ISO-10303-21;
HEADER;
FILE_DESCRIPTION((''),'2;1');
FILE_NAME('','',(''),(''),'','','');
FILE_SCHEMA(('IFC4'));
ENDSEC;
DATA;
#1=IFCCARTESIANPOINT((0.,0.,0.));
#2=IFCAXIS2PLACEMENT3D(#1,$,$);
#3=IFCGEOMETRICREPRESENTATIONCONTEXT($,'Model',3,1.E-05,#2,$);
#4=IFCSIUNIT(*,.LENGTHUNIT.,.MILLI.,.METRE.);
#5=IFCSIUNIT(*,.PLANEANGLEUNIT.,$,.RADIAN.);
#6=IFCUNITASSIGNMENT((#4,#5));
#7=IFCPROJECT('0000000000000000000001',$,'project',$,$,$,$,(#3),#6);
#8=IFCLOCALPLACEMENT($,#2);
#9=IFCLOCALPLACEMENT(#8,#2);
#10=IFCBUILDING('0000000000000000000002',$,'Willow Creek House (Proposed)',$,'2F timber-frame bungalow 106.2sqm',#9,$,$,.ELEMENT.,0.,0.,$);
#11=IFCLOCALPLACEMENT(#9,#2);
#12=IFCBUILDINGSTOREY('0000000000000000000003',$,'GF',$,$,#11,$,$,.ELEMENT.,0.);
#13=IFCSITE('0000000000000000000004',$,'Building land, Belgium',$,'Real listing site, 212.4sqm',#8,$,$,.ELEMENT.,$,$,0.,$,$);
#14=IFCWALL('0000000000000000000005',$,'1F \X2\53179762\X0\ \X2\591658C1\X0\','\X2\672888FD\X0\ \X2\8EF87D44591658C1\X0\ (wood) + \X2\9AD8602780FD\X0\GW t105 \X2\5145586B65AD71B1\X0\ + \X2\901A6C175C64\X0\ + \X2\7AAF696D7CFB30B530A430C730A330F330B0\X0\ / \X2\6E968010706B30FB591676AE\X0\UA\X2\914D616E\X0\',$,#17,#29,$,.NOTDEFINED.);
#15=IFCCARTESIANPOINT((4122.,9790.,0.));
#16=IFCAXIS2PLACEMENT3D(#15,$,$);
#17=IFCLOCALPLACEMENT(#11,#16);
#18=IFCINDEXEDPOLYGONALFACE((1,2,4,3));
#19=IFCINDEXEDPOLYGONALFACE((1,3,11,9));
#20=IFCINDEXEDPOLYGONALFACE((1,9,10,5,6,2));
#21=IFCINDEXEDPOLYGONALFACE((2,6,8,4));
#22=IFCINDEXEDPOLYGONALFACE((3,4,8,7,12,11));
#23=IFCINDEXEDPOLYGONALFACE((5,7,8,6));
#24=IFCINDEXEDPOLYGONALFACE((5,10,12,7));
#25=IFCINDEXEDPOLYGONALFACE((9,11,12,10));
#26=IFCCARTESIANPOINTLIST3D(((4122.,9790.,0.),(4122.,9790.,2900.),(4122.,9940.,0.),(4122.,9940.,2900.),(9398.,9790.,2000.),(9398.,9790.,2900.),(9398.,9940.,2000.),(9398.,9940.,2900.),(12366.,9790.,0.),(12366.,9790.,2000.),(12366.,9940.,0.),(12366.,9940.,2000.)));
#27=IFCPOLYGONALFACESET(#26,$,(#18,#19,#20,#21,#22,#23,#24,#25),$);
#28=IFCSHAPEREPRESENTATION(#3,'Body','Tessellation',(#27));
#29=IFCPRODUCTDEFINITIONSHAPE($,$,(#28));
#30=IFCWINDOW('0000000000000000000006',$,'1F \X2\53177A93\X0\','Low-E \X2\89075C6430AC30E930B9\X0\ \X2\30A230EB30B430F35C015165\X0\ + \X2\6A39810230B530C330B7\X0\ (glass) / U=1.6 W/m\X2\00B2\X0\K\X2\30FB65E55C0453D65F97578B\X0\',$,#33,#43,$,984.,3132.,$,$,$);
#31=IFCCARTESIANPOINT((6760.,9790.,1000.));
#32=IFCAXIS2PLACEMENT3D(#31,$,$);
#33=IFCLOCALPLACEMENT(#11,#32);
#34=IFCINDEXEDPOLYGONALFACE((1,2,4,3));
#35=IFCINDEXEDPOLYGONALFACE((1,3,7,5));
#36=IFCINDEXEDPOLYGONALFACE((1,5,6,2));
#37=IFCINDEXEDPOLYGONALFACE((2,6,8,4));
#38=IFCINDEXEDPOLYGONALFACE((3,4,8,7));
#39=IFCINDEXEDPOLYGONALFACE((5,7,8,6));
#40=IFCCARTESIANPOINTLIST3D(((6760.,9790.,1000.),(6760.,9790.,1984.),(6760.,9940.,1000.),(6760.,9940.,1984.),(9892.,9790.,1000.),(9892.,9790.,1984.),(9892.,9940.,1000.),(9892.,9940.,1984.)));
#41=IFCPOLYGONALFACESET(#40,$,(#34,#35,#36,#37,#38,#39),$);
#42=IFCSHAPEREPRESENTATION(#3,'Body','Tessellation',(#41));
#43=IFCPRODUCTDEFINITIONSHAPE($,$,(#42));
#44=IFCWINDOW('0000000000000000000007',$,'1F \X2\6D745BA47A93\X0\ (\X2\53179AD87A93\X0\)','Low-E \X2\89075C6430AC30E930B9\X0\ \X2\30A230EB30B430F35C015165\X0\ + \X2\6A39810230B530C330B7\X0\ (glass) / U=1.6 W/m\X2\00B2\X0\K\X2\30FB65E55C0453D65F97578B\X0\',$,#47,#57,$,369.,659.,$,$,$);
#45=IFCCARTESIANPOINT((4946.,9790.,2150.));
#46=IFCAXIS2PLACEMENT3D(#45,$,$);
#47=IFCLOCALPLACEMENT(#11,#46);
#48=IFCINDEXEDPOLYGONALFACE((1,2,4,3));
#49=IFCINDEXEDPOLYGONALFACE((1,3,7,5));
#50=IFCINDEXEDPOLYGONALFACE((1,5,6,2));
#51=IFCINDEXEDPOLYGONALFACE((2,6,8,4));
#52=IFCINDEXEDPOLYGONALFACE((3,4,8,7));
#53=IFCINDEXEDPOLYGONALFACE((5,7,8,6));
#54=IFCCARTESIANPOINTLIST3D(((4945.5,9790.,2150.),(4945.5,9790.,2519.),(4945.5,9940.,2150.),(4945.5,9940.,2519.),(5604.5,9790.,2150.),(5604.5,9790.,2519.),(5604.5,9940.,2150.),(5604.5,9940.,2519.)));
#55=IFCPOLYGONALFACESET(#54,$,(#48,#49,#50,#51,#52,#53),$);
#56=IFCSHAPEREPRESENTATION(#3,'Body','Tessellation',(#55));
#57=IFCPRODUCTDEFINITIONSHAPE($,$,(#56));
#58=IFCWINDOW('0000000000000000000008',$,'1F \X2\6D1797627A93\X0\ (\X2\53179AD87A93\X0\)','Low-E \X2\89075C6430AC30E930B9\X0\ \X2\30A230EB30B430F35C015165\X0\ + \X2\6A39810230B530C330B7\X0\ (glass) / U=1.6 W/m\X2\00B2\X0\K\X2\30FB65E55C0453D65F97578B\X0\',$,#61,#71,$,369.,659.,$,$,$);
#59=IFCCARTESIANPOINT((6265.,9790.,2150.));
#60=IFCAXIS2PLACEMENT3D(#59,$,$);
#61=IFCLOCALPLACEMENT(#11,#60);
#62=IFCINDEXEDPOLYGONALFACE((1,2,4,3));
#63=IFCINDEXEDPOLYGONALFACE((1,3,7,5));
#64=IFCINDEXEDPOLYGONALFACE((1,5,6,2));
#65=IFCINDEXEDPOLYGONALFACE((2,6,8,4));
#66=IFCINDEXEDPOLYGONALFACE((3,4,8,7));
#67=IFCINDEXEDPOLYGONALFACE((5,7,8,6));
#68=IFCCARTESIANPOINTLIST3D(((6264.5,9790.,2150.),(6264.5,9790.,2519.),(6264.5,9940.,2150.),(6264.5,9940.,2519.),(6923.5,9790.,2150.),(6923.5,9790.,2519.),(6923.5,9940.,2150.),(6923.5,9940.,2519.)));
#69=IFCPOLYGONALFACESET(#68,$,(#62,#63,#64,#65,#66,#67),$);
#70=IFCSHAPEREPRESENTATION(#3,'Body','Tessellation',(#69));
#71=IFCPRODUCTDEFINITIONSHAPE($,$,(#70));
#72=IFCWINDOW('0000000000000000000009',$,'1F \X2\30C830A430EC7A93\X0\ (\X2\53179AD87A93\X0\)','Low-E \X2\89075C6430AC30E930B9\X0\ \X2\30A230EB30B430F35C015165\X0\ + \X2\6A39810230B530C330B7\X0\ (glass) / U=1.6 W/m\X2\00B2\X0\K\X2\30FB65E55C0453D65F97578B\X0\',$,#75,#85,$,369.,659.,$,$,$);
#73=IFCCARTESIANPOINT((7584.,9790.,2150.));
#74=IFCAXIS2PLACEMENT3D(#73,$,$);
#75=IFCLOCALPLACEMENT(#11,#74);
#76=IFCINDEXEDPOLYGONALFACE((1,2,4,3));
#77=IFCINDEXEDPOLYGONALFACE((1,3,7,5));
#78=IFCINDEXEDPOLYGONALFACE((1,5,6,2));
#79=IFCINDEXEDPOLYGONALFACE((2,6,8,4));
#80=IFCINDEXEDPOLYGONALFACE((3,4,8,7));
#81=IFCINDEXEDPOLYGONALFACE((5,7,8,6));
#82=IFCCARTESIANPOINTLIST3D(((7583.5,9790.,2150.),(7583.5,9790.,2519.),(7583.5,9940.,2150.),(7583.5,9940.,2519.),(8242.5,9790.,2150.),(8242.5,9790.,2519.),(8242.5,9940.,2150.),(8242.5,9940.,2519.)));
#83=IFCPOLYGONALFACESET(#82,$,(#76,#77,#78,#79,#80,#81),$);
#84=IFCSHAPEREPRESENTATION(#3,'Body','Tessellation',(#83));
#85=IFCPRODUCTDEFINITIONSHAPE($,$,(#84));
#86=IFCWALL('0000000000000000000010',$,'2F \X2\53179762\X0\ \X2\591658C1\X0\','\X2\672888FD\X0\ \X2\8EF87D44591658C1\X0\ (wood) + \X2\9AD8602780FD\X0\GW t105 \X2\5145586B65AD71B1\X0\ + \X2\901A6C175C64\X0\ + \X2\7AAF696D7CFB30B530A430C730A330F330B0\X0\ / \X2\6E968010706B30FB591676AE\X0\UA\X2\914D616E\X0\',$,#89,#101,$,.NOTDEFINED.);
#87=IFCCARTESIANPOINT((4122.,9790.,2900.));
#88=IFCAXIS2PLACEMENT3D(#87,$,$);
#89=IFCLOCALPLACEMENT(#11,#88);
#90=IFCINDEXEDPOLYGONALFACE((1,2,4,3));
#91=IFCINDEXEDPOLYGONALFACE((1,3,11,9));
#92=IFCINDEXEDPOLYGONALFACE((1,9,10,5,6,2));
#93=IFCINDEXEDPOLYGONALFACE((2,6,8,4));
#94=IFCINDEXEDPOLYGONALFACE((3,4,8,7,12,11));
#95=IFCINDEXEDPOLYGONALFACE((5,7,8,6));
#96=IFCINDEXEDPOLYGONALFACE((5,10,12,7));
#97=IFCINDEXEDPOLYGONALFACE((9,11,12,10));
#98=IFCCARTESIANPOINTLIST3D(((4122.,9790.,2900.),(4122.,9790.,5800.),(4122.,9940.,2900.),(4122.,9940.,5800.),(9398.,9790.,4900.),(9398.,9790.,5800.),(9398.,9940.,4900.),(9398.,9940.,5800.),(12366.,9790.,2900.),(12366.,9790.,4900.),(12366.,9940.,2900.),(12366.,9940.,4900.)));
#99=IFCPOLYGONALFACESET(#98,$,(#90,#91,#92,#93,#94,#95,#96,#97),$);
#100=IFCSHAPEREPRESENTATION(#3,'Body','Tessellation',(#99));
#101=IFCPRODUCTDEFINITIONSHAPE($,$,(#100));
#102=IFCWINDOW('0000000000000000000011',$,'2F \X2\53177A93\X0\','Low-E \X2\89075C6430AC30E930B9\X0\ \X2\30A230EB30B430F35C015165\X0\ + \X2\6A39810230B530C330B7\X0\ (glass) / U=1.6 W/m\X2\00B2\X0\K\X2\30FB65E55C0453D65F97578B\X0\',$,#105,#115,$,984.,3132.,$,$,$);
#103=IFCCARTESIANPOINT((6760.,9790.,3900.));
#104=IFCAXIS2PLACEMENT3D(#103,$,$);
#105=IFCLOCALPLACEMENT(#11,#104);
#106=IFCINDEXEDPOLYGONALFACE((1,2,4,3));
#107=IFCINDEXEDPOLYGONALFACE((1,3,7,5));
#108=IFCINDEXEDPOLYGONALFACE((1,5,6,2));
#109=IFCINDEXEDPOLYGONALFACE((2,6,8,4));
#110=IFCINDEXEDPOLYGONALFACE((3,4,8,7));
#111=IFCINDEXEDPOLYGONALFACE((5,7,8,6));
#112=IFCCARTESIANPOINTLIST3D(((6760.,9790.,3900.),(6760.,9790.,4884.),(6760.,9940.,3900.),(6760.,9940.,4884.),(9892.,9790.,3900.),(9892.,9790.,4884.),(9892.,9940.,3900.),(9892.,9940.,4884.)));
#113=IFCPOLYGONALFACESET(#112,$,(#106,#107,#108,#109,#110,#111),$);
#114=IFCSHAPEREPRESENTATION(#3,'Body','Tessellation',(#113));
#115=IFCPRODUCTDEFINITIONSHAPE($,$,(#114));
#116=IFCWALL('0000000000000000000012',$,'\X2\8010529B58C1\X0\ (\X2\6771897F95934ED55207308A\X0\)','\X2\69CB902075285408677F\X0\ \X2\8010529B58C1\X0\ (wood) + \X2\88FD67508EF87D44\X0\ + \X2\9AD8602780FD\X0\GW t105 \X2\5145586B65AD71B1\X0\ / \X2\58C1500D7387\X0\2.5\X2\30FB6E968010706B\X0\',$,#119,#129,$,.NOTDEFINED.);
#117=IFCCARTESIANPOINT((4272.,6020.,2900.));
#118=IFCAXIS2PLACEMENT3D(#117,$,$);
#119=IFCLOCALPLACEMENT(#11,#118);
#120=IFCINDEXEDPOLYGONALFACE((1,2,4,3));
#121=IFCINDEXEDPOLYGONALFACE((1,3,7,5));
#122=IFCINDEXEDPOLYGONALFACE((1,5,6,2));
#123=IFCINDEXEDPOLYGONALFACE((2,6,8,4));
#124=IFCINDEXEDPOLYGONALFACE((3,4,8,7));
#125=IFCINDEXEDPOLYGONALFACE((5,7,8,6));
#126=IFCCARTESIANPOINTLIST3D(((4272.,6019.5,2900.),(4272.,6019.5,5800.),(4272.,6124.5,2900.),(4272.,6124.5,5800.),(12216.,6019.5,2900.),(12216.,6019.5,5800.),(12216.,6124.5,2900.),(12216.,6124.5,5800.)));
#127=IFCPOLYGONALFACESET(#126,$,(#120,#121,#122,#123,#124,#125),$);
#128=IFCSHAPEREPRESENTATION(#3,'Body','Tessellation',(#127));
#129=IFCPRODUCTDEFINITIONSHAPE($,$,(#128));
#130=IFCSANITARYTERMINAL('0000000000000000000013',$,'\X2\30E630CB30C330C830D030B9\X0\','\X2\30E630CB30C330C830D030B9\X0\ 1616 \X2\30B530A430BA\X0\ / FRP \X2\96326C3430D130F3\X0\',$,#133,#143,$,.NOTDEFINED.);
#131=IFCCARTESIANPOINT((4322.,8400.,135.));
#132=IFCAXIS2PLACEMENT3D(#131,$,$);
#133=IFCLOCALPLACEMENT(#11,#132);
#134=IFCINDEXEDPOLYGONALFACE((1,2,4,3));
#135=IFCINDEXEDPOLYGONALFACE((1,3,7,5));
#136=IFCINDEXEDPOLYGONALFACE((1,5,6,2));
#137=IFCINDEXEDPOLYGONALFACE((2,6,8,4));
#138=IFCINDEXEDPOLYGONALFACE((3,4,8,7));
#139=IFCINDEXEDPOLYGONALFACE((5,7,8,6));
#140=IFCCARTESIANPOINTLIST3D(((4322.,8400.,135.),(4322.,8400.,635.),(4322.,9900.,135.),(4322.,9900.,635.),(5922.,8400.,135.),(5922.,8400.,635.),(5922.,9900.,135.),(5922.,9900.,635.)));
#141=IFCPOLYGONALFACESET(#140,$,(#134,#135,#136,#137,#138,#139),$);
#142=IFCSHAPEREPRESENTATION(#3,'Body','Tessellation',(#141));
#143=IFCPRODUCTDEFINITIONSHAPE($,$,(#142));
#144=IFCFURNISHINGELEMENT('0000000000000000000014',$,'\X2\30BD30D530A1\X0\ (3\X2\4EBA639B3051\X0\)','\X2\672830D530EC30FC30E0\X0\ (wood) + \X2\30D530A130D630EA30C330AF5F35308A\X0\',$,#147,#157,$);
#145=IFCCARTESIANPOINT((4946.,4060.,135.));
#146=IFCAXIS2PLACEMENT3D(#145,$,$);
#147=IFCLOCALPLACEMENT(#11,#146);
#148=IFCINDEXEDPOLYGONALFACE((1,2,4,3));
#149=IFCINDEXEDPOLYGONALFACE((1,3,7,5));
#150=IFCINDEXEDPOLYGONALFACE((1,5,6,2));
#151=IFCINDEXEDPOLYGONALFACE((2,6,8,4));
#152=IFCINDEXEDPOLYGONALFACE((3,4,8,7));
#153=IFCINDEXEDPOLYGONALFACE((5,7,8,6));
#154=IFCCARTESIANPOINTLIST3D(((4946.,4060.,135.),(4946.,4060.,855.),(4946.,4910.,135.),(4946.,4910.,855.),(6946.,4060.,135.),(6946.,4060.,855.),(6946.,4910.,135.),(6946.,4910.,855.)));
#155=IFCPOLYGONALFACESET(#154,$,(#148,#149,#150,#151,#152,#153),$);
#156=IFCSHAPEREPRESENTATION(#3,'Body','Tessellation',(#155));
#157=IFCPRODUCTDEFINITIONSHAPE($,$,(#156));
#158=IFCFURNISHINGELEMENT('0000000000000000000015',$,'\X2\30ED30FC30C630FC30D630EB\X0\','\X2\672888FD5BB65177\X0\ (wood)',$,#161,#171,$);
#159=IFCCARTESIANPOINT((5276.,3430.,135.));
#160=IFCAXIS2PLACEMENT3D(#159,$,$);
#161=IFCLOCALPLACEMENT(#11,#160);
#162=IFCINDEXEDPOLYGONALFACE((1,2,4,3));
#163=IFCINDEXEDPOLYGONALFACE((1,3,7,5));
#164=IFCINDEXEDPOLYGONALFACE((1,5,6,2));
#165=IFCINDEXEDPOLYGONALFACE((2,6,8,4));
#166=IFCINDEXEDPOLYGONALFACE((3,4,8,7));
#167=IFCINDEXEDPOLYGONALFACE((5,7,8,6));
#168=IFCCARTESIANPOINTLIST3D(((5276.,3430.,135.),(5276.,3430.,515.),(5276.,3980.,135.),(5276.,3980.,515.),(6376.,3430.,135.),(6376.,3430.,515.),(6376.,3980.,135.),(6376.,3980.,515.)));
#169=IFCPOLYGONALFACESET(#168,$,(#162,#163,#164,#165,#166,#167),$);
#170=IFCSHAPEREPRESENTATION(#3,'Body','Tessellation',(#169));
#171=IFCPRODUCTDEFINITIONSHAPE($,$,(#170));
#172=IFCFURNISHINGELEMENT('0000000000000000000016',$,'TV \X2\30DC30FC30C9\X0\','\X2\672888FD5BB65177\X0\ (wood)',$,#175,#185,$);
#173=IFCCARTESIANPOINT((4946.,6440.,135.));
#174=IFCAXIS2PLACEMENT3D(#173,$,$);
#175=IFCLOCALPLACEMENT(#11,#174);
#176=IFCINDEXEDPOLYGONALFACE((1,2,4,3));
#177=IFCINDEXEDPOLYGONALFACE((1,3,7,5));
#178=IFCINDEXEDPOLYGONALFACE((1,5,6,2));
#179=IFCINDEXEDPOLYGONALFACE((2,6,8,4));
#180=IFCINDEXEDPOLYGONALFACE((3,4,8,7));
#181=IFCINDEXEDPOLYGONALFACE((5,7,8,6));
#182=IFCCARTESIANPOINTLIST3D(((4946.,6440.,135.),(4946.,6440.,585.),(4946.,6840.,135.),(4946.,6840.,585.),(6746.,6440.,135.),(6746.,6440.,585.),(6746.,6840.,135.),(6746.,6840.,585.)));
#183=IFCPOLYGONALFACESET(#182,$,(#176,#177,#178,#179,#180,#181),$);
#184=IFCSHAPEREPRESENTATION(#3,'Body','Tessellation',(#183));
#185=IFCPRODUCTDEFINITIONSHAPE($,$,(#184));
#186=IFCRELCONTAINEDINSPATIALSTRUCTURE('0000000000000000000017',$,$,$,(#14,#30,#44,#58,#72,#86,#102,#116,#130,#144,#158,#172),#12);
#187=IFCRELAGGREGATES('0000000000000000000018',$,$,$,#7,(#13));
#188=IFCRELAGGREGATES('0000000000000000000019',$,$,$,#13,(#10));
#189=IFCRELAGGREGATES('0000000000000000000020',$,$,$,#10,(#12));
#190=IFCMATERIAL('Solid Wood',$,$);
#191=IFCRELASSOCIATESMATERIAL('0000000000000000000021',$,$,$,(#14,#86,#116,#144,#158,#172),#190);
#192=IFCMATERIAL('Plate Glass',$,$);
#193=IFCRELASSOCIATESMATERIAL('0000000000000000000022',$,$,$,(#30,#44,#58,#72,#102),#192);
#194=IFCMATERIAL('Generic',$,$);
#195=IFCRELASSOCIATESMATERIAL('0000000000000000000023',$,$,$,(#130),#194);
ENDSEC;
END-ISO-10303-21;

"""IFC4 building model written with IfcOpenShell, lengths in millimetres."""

from ifc_helpers import new_model, si_unit, frame, frame_2d, origin, place, context, project, spatial, rectangle, extrude, material, element, fill, save


model = new_model("IFC4")

# Units and contexts
model_context = context("Model", 3, precision=1e-05, world=origin())
ifc_project = project(units=[si_unit("LENGTHUNIT", "METRE", prefix="MILLI"), si_unit("PLANEANGLEUNIT", "RADIAN")], contexts=[model_context])

# Site, building, storey
site_placement = place(None, origin())
site = spatial("IfcSite", under=ifc_project, at=site_placement, Name="Building land, Belgium", ObjectType="Real listing site, 212.4sqm", CompositionType="ELEMENT", RefElevation=0.0)
building_placement = place(site_placement, origin())
building = spatial("IfcBuilding", under=site, at=building_placement, Name="Willow Creek House (Proposed)", ObjectType="2F timber-frame bungalow 106.2sqm", CompositionType="ELEMENT", ElevationOfRefHeight=0.0, ElevationOfTerrain=0.0)
storey_placement = place(building_placement, origin())
storey = spatial("IfcBuildingStorey", under=building, at=storey_placement, Name="GF", CompositionType="ELEMENT", Elevation=0.0)

# Wall, openings, windows
ifc_material_1 = material(Name="Solid Wood")
wall_1_placement = place(storey_placement, frame((4122.0, 9790.0, 0.0)))
wall_1 = element("IfcWall", 1, at=wall_1_placement, inside=storey, material=ifc_material_1, Name="1F 北面 外壁", Description="木製 軸組外壁 (wood) + 高性能GW t105 充填断熱 + 通気層 + 窯業系サイディング / 準耐火・外皮UA配慮", PredefinedType="NOTDEFINED", context=model_context, shape_type="SweptSolid", body=[
    extrude(rectangle(XDim=8244.0, YDim=150.0, at=frame_2d((4122.0, 75.0))), frame((4122.0, 9790.0, 0.0)), (0.0, 0.0, 1.0), 2900.0),
])
opening_1_placement = place(storey_placement, frame((6760.0, 9790.0, 1000.0)))
opening_1 = element("IfcOpeningElement", 2, at=opening_1_placement, cuts=wall_1, PredefinedType="NOTDEFINED", context=model_context, shape_type="SweptSolid", body=[
    extrude(rectangle(XDim=3132.0, YDim=150.0, at=frame_2d((1566.0, 75.0))), frame((6760.0, 9790.0, 1000.0)), (0.0, 0.0, 1.0), 984.0),
])
opening_2_placement = place(storey_placement, frame((4946.0, 9790.0, 2150.0)))
opening_2 = element("IfcOpeningElement", 3, at=opening_2_placement, cuts=wall_1, PredefinedType="NOTDEFINED", context=model_context, shape_type="SweptSolid", body=[
    extrude(rectangle(XDim=659.0, YDim=150.0, at=frame_2d((329.0, 75.0))), frame((4946.0, 9790.0, 2150.0)), (0.0, 0.0, 1.0), 369.0),
])
opening_3_placement = place(storey_placement, frame((6265.0, 9790.0, 2150.0)))
opening_3 = element("IfcOpeningElement", 4, at=opening_3_placement, cuts=wall_1, PredefinedType="NOTDEFINED", context=model_context, shape_type="SweptSolid", body=[
    extrude(rectangle(XDim=659.0, YDim=150.0, at=frame_2d((329.0, 75.0))), frame((6265.0, 9790.0, 2150.0)), (0.0, 0.0, 1.0), 369.0),
])
opening_4_placement = place(storey_placement, frame((7584.0, 9790.0, 2150.0)))
opening_4 = element("IfcOpeningElement", 5, at=opening_4_placement, cuts=wall_1, PredefinedType="NOTDEFINED", context=model_context, shape_type="SweptSolid", body=[
    extrude(rectangle(XDim=659.0, YDim=150.0, at=frame_2d((329.0, 75.0))), frame((7584.0, 9790.0, 2150.0)), (0.0, 0.0, 1.0), 369.0),
])
ifc_material_2 = material(Name="Plate Glass")
window_1_placement = place(storey_placement, frame((6760.0, 9790.0, 1000.0)))
window_1 = element("IfcWindow", 6, at=window_1_placement, inside=storey, material=ifc_material_2, Name="1F 北窓", Description="Low-E 複層ガラス アルゴン封入 + 樹脂サッシ (glass) / U=1.6 W/m²K・日射取得型", OverallHeight=984.0, OverallWidth=3132.0, context=model_context, shape_type="SweptSolid", body=[
    extrude(rectangle(XDim=3132.0, YDim=150.0, at=frame_2d((1566.0, 75.0))), frame((6760.0, 9790.0, 1000.0)), (0.0, 0.0, 1.0), 984.0),
])
fill(opening_1, window_1)
window_2_placement = place(storey_placement, frame((4946.0, 9790.0, 2150.0)))
window_2 = element("IfcWindow", 7, at=window_2_placement, inside=storey, material=ifc_material_2, Name="1F 浴室窓 (北高窓)", Description="Low-E 複層ガラス アルゴン封入 + 樹脂サッシ (glass) / U=1.6 W/m²K・日射取得型", OverallHeight=369.0, OverallWidth=659.0, context=model_context, shape_type="SweptSolid", body=[
    extrude(rectangle(XDim=659.0, YDim=150.0, at=frame_2d((329.0, 75.0))), frame((4946.0, 9790.0, 2150.0)), (0.0, 0.0, 1.0), 369.0),
])
fill(opening_2, window_2)
window_3_placement = place(storey_placement, frame((6265.0, 9790.0, 2150.0)))
window_3 = element("IfcWindow", 8, at=window_3_placement, inside=storey, material=ifc_material_2, Name="1F 洗面窓 (北高窓)", Description="Low-E 複層ガラス アルゴン封入 + 樹脂サッシ (glass) / U=1.6 W/m²K・日射取得型", OverallHeight=369.0, OverallWidth=659.0, context=model_context, shape_type="SweptSolid", body=[
    extrude(rectangle(XDim=659.0, YDim=150.0, at=frame_2d((329.0, 75.0))), frame((6265.0, 9790.0, 2150.0)), (0.0, 0.0, 1.0), 369.0),
])
fill(opening_3, window_3)
window_4_placement = place(storey_placement, frame((7584.0, 9790.0, 2150.0)))
window_4 = element("IfcWindow", 9, at=window_4_placement, inside=storey, material=ifc_material_2, Name="1F トイレ窓 (北高窓)", Description="Low-E 複層ガラス アルゴン封入 + 樹脂サッシ (glass) / U=1.6 W/m²K・日射取得型", OverallHeight=369.0, OverallWidth=659.0, context=model_context, shape_type="SweptSolid", body=[
    extrude(rectangle(XDim=659.0, YDim=150.0, at=frame_2d((329.0, 75.0))), frame((7584.0, 9790.0, 2150.0)), (0.0, 0.0, 1.0), 369.0),
])
fill(opening_4, window_4)

# Wall, opening, window
wall_2_placement = place(storey_placement, frame((4122.0, 9790.0, 2900.0)))
wall_2 = element("IfcWall", 10, at=wall_2_placement, inside=storey, material=ifc_material_1, Name="2F 北面 外壁", Description="木製 軸組外壁 (wood) + 高性能GW t105 充填断熱 + 通気層 + 窯業系サイディング / 準耐火・外皮UA配慮", PredefinedType="NOTDEFINED", context=model_context, shape_type="SweptSolid", body=[
    extrude(rectangle(XDim=8244.0, YDim=150.0, at=frame_2d((4122.0, 75.0))), frame((4122.0, 9790.0, 2900.0)), (0.0, 0.0, 1.0), 2900.0),
])
opening_5_placement = place(storey_placement, frame((6760.0, 9790.0, 3900.0)))
opening_5 = element("IfcOpeningElement", 11, at=opening_5_placement, cuts=wall_2, PredefinedType="NOTDEFINED", context=model_context, shape_type="SweptSolid", body=[
    extrude(rectangle(XDim=3132.0, YDim=150.0, at=frame_2d((1566.0, 75.0))), frame((6760.0, 9790.0, 3900.0)), (0.0, 0.0, 1.0), 984.0),
])
window_5_placement = place(storey_placement, frame((6760.0, 9790.0, 3900.0)))
window_5 = element("IfcWindow", 12, at=window_5_placement, inside=storey, material=ifc_material_2, Name="2F 北窓", Description="Low-E 複層ガラス アルゴン封入 + 樹脂サッシ (glass) / U=1.6 W/m²K・日射取得型", OverallHeight=984.0, OverallWidth=3132.0, context=model_context, shape_type="SweptSolid", body=[
    extrude(rectangle(XDim=3132.0, YDim=150.0, at=frame_2d((1566.0, 75.0))), frame((6760.0, 9790.0, 3900.0)), (0.0, 0.0, 1.0), 984.0),
])
fill(opening_5, window_5)

# Wall
wall_3_placement = place(storey_placement, frame((4272.0, 6020.0, 2900.0)))
element("IfcWall", 13, at=wall_3_placement, inside=storey, material=ifc_material_1, Name="耐力壁 (東西間仕切り)", Description="構造用合板 耐力壁 (wood) + 製材軸組 + 高性能GW t105 充填断熱 / 壁倍率2.5・準耐火", PredefinedType="NOTDEFINED", context=model_context, shape_type="SweptSolid", body=[
    extrude(rectangle(XDim=7944.0, YDim=105.0, at=frame_2d((3972.0, 52.0))), frame((4272.0, 6020.0, 2900.0)), (0.0, 0.0, 1.0), 2900.0),
])

# Sanitary terminal
ifc_material_3 = material(Name="Generic")
sanitary_terminal_placement = place(storey_placement, frame((4322.0, 8400.0, 135.0)))
element("IfcSanitaryTerminal", 14, at=sanitary_terminal_placement, inside=storey, material=ifc_material_3, Name="ユニットバス", Description="ユニットバス 1616 サイズ / FRP 防水パン", PredefinedType="NOTDEFINED", context=model_context, shape_type="SweptSolid", body=[
    extrude(rectangle(XDim=1600.0, YDim=1500.0, at=frame_2d((800.0, 750.0))), frame((4322.0, 8400.0, 135.0)), (0.0, 0.0, 1.0), 500.0),
])

# Furnishing elements
furnishing_1_placement = place(storey_placement, frame((4946.0, 4060.0, 135.0)))
element("IfcFurnishingElement", 15, at=furnishing_1_placement, inside=storey, material=ifc_material_1, Name="ソファ (3人掛け)", Description="木フレーム (wood) + ファブリック張り", context=model_context, shape_type="SweptSolid", body=[
    extrude(rectangle(XDim=2000.0, YDim=850.0, at=frame_2d((1000.0, 425.0))), frame((4946.0, 4060.0, 135.0)), (0.0, 0.0, 1.0), 720.0),
])
furnishing_2_placement = place(storey_placement, frame((5276.0, 3430.0, 135.0)))
element("IfcFurnishingElement", 16, at=furnishing_2_placement, inside=storey, material=ifc_material_1, Name="ローテーブル", Description="木製家具 (wood)", context=model_context, shape_type="SweptSolid", body=[
    extrude(rectangle(XDim=1100.0, YDim=550.0, at=frame_2d((550.0, 275.0))), frame((5276.0, 3430.0, 135.0)), (0.0, 0.0, 1.0), 380.0),
])
furnishing_3_placement = place(storey_placement, frame((4946.0, 6440.0, 135.0)))
element("IfcFurnishingElement", 17, at=furnishing_3_placement, inside=storey, material=ifc_material_1, Name="TV ボード", Description="木製家具 (wood)", context=model_context, shape_type="SweptSolid", body=[
    extrude(rectangle(XDim=1800.0, YDim=400.0, at=frame_2d((900.0, 200.0))), frame((4946.0, 6440.0, 135.0)), (0.0, 0.0, 1.0), 450.0),
])

save(model, "model.ifc")
